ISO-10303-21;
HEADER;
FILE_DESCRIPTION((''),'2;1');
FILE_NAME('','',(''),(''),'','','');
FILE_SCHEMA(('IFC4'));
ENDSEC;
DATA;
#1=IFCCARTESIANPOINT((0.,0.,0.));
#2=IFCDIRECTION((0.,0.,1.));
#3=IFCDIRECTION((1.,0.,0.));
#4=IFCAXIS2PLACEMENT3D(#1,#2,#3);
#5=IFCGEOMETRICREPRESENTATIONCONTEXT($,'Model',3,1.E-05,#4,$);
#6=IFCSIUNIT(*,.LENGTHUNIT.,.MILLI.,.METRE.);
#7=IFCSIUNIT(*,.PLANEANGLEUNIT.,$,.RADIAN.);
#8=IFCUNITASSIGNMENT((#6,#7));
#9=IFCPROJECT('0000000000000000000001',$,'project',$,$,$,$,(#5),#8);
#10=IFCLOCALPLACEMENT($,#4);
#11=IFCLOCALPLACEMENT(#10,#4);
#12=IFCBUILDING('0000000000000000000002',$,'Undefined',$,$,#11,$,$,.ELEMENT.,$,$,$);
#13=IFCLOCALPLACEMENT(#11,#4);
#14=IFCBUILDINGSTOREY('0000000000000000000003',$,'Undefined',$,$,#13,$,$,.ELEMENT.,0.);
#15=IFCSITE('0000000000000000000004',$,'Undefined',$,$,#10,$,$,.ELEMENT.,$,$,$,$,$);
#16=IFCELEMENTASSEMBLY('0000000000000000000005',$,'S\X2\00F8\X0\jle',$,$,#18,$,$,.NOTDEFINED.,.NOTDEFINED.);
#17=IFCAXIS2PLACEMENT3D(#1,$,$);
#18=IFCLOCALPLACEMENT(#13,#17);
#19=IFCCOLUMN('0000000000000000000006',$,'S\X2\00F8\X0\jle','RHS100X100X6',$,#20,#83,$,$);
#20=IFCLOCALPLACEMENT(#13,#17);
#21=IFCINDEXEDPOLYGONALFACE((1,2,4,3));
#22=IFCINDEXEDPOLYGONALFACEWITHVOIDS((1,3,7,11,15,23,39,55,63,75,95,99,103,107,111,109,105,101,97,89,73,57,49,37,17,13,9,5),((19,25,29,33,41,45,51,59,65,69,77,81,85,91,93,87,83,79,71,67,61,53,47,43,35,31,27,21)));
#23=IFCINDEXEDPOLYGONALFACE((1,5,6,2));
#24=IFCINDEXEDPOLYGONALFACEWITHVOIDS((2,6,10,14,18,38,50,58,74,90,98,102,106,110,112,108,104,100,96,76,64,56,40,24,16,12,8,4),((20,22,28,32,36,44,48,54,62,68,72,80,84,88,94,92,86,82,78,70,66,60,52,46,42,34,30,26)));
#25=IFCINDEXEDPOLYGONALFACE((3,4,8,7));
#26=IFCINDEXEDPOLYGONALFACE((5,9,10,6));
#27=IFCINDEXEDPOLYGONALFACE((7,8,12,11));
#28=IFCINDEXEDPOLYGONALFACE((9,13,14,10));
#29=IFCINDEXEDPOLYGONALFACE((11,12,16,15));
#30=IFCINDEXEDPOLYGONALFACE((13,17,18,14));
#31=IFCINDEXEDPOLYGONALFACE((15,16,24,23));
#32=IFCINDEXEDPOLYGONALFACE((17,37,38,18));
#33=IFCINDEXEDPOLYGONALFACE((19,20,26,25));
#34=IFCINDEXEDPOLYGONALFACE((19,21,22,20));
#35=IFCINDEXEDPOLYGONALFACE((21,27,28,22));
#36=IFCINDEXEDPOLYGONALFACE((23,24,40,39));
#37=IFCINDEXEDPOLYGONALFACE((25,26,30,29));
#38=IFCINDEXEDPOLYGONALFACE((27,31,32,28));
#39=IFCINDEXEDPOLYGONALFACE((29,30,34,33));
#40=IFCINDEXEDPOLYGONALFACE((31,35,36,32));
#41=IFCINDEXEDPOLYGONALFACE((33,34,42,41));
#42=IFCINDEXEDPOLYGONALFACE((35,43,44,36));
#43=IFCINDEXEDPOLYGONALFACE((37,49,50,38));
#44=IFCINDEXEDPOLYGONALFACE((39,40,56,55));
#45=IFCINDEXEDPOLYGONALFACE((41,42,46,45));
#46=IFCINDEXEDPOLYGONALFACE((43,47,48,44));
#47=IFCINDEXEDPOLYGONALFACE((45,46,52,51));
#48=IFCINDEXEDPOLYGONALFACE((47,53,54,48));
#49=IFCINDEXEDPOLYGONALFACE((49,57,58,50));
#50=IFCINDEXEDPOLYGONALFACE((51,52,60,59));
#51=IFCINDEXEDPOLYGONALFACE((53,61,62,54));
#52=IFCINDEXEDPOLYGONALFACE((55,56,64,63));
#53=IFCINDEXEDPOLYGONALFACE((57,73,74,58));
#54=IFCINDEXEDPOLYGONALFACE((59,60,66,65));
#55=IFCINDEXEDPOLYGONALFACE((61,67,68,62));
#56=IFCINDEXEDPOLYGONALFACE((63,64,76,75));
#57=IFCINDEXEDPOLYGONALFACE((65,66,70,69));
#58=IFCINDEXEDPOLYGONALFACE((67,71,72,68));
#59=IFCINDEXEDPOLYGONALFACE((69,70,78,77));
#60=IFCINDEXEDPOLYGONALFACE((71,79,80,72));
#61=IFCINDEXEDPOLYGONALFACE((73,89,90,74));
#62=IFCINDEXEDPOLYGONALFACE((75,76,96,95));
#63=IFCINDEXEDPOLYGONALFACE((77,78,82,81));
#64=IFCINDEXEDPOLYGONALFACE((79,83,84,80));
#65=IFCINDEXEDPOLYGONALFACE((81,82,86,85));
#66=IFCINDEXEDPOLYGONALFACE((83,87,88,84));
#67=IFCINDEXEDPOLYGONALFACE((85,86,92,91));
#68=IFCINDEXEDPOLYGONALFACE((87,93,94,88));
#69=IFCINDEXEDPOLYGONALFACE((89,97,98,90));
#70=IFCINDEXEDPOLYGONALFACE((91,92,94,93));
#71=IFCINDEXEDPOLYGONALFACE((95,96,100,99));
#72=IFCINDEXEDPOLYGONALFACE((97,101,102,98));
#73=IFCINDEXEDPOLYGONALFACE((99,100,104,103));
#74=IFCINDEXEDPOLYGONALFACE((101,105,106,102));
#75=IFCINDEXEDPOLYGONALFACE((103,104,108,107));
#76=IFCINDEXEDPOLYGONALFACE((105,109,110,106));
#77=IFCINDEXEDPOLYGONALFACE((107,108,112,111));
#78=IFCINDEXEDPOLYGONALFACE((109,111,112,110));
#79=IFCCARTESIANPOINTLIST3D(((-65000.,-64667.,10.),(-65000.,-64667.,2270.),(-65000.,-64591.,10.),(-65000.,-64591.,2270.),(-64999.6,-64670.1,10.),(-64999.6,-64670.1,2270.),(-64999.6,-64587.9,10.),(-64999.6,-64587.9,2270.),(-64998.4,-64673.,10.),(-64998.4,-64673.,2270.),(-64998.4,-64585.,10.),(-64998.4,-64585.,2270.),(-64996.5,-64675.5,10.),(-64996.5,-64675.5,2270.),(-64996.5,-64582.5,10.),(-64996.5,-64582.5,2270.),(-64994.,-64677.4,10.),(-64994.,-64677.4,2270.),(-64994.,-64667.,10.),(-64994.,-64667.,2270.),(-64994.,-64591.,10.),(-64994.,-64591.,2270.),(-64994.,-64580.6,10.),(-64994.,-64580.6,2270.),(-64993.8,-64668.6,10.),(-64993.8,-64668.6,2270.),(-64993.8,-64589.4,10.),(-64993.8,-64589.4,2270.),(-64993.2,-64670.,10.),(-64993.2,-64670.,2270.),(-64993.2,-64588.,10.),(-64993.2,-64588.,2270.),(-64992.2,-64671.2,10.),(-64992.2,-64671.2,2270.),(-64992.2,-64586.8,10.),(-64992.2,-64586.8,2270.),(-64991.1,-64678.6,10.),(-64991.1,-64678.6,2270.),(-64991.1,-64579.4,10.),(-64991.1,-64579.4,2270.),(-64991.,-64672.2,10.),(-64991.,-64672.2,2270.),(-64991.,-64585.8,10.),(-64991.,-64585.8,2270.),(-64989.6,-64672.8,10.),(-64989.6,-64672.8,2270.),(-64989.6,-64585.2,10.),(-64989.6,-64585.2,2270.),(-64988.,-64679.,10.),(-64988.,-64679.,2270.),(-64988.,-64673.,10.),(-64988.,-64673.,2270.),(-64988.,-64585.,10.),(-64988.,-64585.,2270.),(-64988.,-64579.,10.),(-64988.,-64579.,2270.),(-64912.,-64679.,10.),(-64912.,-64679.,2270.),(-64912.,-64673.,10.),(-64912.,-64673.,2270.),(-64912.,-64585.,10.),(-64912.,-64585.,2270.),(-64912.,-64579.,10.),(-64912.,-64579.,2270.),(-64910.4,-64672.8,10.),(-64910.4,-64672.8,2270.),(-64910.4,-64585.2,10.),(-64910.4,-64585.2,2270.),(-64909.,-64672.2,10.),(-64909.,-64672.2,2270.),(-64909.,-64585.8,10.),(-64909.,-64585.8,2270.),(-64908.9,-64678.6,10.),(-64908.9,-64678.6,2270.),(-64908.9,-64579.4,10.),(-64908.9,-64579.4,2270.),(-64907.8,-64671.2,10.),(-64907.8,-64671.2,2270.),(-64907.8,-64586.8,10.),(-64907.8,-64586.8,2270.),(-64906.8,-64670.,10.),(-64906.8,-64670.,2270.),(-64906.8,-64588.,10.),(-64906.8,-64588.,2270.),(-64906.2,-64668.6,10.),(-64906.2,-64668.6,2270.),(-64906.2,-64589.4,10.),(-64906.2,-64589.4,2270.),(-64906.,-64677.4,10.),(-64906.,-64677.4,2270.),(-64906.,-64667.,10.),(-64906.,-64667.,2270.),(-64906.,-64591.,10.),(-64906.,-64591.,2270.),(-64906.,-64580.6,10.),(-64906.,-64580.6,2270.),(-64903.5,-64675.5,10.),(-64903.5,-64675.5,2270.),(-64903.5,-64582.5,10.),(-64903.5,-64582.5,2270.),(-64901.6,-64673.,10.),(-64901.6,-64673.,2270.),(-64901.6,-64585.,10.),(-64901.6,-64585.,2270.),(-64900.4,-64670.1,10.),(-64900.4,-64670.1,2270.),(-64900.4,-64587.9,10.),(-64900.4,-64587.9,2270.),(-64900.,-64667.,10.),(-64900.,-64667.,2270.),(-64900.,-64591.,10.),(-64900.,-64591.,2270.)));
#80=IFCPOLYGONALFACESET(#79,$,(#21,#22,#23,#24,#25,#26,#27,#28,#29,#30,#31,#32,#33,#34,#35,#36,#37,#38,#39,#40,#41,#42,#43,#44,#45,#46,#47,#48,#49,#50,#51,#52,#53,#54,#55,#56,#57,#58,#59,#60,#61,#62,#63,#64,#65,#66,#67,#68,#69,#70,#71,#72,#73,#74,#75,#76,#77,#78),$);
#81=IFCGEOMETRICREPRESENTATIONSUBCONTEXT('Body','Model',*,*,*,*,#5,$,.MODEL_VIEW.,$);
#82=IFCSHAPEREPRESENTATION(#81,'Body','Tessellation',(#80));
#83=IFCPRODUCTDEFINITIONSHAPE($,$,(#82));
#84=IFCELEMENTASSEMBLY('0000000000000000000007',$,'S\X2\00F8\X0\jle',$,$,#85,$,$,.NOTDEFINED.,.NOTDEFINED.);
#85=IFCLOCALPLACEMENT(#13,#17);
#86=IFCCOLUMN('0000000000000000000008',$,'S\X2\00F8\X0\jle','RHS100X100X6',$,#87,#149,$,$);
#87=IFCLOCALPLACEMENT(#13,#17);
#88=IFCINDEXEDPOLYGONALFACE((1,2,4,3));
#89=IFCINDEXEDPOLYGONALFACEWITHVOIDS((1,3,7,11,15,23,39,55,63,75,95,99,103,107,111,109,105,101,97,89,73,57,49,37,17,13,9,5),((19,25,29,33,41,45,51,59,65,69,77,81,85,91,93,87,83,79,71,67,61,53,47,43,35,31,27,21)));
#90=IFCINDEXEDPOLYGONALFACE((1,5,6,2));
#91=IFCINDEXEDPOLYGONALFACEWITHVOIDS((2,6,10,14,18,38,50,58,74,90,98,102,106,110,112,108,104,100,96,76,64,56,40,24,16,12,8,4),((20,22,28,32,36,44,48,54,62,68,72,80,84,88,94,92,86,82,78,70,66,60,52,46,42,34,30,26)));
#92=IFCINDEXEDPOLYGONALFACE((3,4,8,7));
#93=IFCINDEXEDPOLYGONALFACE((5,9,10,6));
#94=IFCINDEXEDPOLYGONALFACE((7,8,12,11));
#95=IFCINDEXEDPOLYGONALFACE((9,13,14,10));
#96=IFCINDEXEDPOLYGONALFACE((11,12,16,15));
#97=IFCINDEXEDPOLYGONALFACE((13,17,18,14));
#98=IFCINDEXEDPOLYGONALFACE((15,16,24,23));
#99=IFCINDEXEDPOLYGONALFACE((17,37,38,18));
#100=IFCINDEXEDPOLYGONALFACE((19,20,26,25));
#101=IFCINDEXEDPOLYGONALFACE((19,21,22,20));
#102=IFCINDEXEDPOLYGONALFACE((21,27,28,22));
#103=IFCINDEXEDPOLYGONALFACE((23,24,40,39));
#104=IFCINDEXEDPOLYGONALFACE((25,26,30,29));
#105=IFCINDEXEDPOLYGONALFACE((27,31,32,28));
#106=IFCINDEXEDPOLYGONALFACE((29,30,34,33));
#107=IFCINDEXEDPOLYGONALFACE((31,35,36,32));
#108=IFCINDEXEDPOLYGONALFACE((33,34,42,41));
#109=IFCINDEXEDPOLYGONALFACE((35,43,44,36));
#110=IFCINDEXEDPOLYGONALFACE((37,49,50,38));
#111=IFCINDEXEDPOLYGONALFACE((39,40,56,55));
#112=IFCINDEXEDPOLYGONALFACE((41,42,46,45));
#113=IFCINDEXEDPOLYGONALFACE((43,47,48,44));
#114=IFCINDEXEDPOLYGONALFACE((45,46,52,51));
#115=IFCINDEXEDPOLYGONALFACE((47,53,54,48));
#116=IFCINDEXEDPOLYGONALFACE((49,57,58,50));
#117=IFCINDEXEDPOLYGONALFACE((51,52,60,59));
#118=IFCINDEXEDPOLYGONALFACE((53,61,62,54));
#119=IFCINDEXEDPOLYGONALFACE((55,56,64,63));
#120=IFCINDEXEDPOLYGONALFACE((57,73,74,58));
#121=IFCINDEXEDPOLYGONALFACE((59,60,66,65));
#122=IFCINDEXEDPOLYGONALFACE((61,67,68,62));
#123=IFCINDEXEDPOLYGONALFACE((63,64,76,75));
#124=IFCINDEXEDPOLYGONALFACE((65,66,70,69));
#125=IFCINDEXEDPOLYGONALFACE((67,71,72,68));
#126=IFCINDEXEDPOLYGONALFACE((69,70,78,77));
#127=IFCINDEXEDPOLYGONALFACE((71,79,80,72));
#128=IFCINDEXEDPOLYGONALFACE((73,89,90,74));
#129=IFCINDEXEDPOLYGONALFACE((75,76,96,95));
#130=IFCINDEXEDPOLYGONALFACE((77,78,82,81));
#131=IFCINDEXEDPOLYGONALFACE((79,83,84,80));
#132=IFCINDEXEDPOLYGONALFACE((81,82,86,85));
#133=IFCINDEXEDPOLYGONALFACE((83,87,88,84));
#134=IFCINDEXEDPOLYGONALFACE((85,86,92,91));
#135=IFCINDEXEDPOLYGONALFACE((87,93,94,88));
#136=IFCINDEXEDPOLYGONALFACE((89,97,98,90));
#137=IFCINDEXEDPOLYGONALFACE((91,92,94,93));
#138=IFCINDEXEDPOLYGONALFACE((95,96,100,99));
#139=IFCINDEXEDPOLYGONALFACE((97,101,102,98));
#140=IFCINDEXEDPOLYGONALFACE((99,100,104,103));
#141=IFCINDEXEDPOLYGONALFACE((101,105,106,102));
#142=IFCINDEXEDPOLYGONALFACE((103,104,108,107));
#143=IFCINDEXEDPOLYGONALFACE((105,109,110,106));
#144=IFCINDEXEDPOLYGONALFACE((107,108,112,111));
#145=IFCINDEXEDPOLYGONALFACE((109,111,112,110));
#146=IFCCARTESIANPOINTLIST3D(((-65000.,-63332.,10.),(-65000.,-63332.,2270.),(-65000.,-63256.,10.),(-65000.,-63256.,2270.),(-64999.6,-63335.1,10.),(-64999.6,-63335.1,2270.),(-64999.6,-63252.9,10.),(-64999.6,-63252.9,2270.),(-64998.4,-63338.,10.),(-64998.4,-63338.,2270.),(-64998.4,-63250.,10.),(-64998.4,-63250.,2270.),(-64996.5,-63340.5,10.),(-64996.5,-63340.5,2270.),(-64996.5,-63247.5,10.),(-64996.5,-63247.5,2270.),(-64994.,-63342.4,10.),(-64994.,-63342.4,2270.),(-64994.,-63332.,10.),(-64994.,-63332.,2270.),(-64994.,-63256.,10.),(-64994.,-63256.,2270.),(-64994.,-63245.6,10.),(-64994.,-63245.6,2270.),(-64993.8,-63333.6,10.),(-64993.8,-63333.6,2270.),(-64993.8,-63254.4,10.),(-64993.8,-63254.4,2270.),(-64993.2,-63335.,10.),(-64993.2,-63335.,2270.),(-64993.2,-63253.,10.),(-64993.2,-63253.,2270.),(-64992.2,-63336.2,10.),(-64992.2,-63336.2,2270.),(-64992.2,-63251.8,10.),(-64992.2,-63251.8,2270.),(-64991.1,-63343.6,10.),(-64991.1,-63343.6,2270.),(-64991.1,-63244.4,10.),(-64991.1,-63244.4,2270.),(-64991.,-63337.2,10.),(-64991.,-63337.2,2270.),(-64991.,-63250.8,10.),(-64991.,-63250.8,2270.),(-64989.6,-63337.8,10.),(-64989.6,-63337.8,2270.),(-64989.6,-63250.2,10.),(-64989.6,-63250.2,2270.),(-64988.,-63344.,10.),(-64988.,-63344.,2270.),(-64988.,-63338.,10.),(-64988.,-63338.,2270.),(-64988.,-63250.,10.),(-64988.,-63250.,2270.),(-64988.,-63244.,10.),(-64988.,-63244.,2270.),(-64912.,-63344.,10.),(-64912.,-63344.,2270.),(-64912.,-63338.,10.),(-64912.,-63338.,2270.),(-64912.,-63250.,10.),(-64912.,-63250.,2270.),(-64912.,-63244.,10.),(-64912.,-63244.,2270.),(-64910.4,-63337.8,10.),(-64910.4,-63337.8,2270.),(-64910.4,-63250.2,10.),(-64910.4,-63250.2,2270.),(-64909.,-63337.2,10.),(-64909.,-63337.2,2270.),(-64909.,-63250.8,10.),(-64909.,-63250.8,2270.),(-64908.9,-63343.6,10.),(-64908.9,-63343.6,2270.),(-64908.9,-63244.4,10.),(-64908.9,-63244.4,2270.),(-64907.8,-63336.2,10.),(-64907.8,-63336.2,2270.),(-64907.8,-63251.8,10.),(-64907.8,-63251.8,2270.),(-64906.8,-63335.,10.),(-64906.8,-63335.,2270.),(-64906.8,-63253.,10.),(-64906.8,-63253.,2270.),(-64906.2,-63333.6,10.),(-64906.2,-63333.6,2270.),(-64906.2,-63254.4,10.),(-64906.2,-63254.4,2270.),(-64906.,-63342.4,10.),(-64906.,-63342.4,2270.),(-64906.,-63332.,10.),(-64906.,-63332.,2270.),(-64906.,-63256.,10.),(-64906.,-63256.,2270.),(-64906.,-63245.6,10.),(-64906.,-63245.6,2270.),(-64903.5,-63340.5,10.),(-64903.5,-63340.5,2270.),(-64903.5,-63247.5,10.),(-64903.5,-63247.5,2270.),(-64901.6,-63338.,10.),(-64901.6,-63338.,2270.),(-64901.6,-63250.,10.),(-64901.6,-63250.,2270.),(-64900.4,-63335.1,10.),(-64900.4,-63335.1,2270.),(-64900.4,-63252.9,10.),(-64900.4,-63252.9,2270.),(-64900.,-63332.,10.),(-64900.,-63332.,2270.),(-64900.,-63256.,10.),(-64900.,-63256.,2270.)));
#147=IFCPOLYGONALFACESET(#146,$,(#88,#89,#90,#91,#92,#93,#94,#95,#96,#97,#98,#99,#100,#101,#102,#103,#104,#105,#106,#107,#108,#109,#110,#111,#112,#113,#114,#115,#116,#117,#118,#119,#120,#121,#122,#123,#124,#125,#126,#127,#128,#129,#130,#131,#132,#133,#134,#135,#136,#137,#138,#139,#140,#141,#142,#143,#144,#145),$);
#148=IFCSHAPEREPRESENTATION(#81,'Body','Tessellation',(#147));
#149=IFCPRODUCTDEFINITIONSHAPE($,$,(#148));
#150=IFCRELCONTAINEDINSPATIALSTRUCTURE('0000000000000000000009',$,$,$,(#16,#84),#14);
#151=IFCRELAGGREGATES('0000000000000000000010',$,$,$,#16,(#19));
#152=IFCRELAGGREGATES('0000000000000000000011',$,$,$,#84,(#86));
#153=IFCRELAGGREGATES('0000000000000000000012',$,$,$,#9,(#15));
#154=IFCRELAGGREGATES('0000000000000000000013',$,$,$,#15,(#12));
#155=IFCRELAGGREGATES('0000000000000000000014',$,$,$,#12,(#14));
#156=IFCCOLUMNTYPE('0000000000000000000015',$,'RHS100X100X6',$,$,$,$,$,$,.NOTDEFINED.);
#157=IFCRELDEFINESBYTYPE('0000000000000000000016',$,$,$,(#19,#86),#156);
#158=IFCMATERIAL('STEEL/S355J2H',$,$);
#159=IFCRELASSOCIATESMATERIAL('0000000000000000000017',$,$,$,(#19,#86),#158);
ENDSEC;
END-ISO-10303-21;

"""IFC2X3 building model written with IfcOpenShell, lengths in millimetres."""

from ifc_helpers import new_model, si_unit, frame, origin_with_axes, origin_2d_with_axis, place, context, subcontext, project, spatial, hollow_rectangle, extrude, clip, halfspace, material, type_object, element, aggregate, save


model = new_model("IFC2X3")

# Units and contexts
model_context = context("Model", 3, precision=1e-05, world=origin_with_axes())
body_context = subcontext(model_context, "Body", "Model", "MODEL_VIEW")
ifc_project = project(units=[si_unit("LENGTHUNIT", "METRE", prefix="MILLI"), si_unit("PLANEANGLEUNIT", "RADIAN")], contexts=[model_context])

# Site, building, storey
site_placement = place(None, origin_with_axes())
site = spatial("IfcSite", under=ifc_project, at=site_placement, Name="Undefined", CompositionType="ELEMENT")
building_placement = place(site_placement, origin_with_axes())
building = spatial("IfcBuilding", under=site, at=building_placement, Name="Undefined", CompositionType="ELEMENT")
storey_placement = place(building_placement, origin_with_axes())
storey = spatial("IfcBuildingStorey", under=building, at=storey_placement, Name="Undefined", CompositionType="ELEMENT", Elevation=0.0)

# Element assemblies, columns
ifc_material_1 = material(Name="STEEL/S355J2H")
column_type = type_object("IfcColumnType", Name="RHS100X100X6", PredefinedType="NOTDEFINED")
assembly_1_placement = place(storey_placement, origin_with_axes())
assembly_1 = element("IfcElementAssembly", 1, at=assembly_1_placement, inside=storey, Name="Søjle", AssemblyPlace="NOTDEFINED", PredefinedType="NOTDEFINED")
column_1_placement = place(assembly_1_placement, frame((-64950.0, -64629.0, 0.0), z_axis=(0.0, 0.0, 1.0), x_axis=(0.0, 1.0, 0.0)))
column_1 = element("IfcColumn", 2, at=column_1_placement, type_object=column_type, material=ifc_material_1, Name="Søjle", Description="RHS100X100X6", context=body_context, shape_type="Clipping", body=[
    clip(clip(extrude(hollow_rectangle(XDim=100.0, YDim=100.0, WallThickness=6.0, InnerFilletRadius=6.0, OuterFilletRadius=12.0, at=origin_2d_with_axis()), frame((0.0, 0.0, 2280.0), z_axis=(0.0, 0.0, -1.0), x_axis=(0.0, 1.0, 0.0)), (0.0, 0.0, 1.0), 2280.0), halfspace(frame((-50.0, 0.0, 2270.0), z_axis=(0.0, 0.0, -1.0), x_axis=(0.0, -1.0, 0.0)), True)), halfspace(frame((0.0, -50.0, 10.0), z_axis=(0.0, 0.0, 1.0), x_axis=(-1.0, 0.0, 0.0)), True)),
])
assembly_2_placement = place(storey_placement, origin_with_axes())
assembly_2 = element("IfcElementAssembly", 3, at=assembly_2_placement, inside=storey, Name="Søjle", AssemblyPlace="NOTDEFINED", PredefinedType="NOTDEFINED")
column_2_placement = place(assembly_2_placement, frame((-64950.0, -63294.0, 0.0), z_axis=(0.0, 0.0, 1.0), x_axis=(0.0, 1.0, 0.0)))
column_2 = element("IfcColumn", 4, at=column_2_placement, type_object=column_type, material=ifc_material_1, Name="Søjle", Description="RHS100X100X6", context=body_context, shape_type="Clipping", body=[
    clip(clip(extrude(hollow_rectangle(XDim=100.0, YDim=100.0, WallThickness=6.0, InnerFilletRadius=6.0, OuterFilletRadius=12.0, at=origin_2d_with_axis()), frame((0.0, 0.0, 2280.0), z_axis=(0.0, 0.0, -1.0), x_axis=(0.0, 1.0, 0.0)), (0.0, 0.0, 1.0), 2280.0), halfspace(frame((-50.0, 0.0, 2270.0), z_axis=(0.0, 0.0, -1.0), x_axis=(0.0, -1.0, 0.0)), True)), halfspace(frame((0.0, -50.0, 10.0), z_axis=(0.0, 0.0, 1.0), x_axis=(-1.0, 0.0, 0.0)), True)),
])

aggregate(assembly_1, [column_1])
aggregate(assembly_2, [column_2])

save(model, "model.ifc")
